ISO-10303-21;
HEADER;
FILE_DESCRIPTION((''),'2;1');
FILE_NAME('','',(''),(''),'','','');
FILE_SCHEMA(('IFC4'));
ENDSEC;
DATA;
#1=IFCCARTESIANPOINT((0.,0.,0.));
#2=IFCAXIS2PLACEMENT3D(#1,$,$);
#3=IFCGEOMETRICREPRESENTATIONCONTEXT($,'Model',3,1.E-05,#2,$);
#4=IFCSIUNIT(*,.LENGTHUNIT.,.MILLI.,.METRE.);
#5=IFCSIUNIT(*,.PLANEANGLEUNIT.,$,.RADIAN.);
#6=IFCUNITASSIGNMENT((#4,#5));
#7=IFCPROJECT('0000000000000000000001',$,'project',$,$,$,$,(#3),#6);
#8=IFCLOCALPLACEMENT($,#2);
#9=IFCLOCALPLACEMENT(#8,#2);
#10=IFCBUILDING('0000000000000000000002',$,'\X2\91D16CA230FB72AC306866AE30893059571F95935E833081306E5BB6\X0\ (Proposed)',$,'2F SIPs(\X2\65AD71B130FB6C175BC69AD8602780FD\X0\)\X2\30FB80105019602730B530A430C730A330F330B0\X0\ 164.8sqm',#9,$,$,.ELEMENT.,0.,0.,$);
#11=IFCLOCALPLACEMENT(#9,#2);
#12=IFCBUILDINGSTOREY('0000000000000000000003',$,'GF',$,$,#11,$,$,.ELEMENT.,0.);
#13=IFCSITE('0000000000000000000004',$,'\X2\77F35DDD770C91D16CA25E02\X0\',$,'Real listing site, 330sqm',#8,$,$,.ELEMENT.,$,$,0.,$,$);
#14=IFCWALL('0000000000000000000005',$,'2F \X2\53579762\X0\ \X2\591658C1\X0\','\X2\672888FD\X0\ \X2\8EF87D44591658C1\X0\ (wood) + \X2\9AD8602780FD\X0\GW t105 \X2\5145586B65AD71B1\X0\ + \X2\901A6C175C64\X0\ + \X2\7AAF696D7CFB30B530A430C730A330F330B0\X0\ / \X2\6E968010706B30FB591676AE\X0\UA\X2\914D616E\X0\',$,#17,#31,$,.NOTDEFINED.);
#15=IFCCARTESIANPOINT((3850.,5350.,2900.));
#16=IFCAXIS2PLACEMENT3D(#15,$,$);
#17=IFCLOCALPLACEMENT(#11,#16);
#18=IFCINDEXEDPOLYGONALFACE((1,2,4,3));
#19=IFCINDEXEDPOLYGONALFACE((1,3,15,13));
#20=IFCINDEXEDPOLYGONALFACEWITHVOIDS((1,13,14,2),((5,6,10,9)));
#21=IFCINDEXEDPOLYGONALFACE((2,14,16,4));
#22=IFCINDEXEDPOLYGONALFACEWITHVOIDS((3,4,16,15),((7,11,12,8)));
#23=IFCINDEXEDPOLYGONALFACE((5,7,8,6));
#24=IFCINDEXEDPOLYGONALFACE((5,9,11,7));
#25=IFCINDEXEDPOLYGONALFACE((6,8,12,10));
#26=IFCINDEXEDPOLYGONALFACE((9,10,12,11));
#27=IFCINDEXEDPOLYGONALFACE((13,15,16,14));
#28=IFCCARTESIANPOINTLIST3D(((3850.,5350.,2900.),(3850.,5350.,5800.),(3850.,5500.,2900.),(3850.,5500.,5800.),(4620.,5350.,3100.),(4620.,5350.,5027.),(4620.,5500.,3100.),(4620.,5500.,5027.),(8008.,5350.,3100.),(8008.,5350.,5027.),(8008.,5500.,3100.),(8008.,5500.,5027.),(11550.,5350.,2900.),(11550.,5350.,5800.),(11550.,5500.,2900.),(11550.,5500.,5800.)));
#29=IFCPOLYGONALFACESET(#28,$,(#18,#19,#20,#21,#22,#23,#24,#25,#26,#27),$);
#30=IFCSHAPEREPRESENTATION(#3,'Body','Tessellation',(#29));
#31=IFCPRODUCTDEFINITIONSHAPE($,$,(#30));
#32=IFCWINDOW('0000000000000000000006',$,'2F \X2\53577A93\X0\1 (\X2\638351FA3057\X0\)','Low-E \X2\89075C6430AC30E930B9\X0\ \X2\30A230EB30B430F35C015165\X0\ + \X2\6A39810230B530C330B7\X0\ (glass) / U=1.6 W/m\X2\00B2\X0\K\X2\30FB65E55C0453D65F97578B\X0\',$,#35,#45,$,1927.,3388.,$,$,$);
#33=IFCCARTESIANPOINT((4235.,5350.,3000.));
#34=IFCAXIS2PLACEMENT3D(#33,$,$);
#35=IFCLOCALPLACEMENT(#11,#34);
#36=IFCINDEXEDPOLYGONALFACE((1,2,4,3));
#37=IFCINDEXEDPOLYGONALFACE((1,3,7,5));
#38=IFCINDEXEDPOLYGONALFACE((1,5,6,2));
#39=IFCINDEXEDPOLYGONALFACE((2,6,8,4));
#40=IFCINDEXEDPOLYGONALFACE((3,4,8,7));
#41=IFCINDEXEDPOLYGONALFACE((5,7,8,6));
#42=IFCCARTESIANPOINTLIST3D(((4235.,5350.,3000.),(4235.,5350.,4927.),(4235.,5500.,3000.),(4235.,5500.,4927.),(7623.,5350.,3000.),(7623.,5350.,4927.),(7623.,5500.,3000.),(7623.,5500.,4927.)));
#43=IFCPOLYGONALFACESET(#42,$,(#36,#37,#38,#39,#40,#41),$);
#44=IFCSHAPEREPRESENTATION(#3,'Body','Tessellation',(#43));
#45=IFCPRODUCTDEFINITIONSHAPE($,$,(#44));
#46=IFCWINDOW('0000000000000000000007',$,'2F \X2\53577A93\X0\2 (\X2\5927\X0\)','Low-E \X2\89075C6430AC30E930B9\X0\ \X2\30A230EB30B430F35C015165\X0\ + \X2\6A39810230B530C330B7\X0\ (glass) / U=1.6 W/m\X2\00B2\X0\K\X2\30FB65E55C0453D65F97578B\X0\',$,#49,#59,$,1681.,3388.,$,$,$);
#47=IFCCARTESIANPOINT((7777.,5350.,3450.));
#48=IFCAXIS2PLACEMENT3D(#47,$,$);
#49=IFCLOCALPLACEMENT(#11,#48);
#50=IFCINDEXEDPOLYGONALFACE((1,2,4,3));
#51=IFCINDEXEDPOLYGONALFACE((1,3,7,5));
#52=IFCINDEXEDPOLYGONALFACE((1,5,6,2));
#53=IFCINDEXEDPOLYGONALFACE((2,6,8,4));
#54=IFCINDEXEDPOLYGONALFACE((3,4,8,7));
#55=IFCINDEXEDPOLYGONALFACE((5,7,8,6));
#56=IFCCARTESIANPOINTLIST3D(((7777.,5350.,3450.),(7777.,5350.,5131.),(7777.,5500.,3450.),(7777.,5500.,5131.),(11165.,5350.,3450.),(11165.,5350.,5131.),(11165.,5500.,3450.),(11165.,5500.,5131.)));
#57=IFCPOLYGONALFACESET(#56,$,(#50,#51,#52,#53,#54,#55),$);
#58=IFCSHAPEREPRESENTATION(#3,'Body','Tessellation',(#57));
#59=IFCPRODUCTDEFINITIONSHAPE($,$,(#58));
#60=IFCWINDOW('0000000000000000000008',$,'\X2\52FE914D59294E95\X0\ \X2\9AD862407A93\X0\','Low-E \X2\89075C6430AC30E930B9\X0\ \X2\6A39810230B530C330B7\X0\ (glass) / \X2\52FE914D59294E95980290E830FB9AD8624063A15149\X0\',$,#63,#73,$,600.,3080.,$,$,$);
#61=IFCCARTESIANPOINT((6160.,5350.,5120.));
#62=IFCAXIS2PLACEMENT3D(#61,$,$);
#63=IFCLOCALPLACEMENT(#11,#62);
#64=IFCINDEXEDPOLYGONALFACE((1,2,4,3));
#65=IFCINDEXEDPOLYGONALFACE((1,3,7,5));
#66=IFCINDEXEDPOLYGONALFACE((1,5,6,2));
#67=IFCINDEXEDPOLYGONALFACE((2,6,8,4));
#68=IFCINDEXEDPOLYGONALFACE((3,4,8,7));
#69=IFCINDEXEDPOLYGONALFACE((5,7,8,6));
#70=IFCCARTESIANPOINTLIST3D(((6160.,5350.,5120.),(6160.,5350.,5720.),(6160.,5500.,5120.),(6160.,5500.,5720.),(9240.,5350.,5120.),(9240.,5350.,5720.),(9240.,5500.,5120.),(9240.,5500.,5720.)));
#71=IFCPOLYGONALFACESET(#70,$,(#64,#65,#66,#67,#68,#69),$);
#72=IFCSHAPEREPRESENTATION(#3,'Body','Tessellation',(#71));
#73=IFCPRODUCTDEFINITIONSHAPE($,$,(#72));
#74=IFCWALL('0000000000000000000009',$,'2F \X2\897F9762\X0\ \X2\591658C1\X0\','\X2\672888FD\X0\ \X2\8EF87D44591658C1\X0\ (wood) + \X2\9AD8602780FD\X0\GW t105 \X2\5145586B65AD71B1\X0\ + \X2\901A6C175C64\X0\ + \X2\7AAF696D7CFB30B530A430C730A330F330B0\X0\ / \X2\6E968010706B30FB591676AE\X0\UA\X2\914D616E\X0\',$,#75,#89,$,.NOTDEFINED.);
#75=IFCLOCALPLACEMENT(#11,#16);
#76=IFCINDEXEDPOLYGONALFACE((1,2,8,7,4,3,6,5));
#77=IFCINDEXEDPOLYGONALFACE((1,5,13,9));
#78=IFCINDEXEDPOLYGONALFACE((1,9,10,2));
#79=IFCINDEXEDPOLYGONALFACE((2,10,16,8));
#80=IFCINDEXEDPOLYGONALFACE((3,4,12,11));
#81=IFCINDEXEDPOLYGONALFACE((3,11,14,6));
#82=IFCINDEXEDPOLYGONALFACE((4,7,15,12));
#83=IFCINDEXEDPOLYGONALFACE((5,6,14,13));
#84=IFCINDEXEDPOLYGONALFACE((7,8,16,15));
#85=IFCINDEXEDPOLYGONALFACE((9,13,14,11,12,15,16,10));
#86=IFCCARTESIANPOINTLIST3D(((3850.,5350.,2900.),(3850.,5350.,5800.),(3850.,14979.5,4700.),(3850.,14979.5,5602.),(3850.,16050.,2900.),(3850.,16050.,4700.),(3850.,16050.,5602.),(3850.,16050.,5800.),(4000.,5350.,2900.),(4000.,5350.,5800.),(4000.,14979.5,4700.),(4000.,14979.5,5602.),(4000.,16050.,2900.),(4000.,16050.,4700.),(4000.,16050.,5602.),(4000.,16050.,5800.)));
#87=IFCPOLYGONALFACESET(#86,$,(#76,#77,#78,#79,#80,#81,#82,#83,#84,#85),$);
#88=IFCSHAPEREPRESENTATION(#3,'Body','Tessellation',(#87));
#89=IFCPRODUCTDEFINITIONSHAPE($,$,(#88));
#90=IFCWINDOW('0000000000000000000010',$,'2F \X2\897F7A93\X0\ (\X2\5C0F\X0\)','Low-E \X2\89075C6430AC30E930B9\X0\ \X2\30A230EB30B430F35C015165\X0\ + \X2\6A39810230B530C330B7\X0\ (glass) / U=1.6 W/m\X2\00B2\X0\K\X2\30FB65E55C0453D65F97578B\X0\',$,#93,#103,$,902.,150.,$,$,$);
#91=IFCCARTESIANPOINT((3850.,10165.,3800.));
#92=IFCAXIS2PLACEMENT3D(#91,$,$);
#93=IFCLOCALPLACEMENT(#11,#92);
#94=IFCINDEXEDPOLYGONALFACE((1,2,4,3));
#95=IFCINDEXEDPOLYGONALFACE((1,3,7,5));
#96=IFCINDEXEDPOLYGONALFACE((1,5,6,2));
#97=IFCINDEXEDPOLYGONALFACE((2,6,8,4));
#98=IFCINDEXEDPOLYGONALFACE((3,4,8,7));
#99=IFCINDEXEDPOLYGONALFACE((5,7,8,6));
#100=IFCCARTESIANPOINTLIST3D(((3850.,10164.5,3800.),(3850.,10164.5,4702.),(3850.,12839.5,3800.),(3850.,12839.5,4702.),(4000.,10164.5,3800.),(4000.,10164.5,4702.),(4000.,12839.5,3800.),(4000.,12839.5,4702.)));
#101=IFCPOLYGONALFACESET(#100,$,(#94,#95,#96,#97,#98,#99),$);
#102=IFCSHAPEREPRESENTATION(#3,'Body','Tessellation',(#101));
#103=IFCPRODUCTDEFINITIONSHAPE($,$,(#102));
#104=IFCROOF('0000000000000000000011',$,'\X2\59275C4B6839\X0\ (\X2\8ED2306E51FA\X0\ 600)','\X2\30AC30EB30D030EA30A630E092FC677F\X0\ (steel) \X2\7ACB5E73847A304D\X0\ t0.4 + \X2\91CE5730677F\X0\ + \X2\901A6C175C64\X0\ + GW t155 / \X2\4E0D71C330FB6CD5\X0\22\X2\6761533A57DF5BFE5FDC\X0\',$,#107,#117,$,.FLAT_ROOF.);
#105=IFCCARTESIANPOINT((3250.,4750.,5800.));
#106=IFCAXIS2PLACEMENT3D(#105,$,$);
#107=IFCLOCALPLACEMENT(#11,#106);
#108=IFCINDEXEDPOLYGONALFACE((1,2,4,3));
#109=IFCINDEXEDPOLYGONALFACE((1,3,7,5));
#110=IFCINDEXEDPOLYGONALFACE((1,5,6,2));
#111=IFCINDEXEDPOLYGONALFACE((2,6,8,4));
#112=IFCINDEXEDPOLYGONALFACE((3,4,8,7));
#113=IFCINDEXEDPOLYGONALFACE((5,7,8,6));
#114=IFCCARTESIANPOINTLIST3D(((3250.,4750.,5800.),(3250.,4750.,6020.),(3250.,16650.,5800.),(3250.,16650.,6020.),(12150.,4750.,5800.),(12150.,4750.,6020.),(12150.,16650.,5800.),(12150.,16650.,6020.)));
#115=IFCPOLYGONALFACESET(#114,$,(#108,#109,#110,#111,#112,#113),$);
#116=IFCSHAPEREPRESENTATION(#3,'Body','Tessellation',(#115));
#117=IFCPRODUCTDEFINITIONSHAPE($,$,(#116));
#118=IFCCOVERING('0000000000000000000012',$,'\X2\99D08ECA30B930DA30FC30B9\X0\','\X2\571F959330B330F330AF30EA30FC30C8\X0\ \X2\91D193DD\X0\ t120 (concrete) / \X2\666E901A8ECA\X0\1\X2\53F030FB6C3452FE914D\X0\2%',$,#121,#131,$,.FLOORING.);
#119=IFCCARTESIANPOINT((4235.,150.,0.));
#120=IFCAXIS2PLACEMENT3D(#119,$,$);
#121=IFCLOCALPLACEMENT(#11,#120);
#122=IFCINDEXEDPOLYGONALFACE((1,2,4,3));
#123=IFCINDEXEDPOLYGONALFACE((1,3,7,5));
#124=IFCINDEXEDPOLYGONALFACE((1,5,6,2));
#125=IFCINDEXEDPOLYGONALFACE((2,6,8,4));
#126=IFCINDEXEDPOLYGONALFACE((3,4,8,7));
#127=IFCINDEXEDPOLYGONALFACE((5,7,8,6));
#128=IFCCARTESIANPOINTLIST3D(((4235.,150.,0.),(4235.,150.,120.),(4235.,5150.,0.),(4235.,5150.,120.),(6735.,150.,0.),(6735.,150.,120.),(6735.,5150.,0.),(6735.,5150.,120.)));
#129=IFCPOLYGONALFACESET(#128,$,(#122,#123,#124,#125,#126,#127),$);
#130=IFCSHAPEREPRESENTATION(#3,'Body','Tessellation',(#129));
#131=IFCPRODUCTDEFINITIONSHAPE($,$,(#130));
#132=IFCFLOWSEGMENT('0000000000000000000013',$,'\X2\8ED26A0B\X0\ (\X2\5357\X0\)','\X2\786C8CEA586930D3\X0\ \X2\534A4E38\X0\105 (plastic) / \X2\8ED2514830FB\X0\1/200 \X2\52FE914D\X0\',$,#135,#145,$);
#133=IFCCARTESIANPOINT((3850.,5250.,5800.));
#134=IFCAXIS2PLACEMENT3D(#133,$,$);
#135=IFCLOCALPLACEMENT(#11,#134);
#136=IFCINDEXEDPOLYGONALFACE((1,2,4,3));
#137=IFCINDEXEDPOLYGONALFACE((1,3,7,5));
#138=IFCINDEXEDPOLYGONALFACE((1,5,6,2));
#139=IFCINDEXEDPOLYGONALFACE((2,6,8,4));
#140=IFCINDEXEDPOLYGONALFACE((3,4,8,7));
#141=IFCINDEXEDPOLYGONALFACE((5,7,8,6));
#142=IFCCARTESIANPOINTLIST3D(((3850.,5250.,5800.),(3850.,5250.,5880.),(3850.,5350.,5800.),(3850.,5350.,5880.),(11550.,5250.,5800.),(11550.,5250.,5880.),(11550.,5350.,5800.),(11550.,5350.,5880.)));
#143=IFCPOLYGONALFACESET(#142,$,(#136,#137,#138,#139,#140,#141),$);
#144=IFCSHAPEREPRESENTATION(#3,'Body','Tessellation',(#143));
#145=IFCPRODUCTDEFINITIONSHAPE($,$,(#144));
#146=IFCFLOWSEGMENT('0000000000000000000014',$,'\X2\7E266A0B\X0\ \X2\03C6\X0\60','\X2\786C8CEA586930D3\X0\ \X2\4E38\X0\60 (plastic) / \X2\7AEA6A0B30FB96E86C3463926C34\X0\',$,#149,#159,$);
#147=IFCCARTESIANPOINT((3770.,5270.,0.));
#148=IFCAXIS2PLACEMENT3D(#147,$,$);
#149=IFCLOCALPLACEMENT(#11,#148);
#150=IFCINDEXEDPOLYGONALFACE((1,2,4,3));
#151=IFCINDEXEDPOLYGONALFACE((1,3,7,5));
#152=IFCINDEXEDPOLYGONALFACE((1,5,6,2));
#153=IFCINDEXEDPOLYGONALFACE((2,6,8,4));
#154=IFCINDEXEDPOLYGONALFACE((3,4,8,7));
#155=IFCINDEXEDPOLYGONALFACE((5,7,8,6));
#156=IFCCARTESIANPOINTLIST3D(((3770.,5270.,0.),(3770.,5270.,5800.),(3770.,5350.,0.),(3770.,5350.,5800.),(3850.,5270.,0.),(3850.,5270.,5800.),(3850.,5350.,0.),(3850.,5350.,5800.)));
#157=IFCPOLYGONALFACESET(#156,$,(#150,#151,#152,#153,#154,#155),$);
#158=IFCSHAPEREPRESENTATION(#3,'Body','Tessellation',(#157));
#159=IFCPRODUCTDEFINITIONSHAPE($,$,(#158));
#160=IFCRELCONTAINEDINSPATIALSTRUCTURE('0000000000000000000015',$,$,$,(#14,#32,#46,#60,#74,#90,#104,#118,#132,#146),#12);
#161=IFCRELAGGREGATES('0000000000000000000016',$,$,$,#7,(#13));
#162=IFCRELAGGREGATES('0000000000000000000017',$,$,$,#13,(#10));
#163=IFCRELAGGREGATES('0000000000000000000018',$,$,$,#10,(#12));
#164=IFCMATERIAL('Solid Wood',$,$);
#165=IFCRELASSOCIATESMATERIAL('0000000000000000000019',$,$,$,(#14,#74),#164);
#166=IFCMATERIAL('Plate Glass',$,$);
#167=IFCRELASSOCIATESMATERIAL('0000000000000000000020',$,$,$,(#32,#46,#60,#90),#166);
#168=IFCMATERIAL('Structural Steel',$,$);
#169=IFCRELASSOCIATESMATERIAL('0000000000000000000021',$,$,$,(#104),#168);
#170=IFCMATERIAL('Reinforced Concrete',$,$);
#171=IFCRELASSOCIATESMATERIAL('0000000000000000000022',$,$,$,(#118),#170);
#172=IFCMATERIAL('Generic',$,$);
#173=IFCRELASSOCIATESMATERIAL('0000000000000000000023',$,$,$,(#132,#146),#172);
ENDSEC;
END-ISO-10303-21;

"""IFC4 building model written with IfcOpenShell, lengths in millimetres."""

from ifc_helpers import new_model, si_unit, frame, frame_2d, origin, place, context, project, spatial, rectangle, extrude, material, element, fill, save


model = new_model("IFC4")

# Units and contexts
model_context = context("Model", 3, precision=1e-05, world=origin())
ifc_project = project(units=[si_unit("LENGTHUNIT", "METRE", prefix="MILLI"), si_unit("PLANEANGLEUNIT", "RADIAN")], contexts=[model_context])

# Site, building, storey
site_placement = place(None, origin())
site = spatial("IfcSite", under=ifc_project, at=site_placement, Name="石川県金沢市", ObjectType="Real listing site, 330sqm", CompositionType="ELEMENT", RefElevation=0.0)
building_placement = place(site_placement, origin())
building = spatial("IfcBuilding", under=site, at=building_placement, Name="金沢・犬と暮らす土間広めの家 (Proposed)", ObjectType="2F SIPs(断熱・気密高性能)・耐候性サイディング 164.8sqm", CompositionType="ELEMENT", ElevationOfRefHeight=0.0, ElevationOfTerrain=0.0)
storey_placement = place(building_placement, origin())
storey = spatial("IfcBuildingStorey", under=building, at=storey_placement, Name="GF", CompositionType="ELEMENT", Elevation=0.0)

# Shared definitions
ifc_material_1 = material(Name="Solid Wood")

# Shared definitions
ifc_material_2 = material(Name="Reinforced Concrete")

# Shared definitions
ifc_material_3 = material(Name="Plate Glass")

# Wall, openings, windows
wall_1_placement = place(storey_placement, frame((3850.0, 5350.0, 2900.0)))
wall_1 = element("IfcWall", 1, at=wall_1_placement, inside=storey, material=ifc_material_1, Name="2F 南面 外壁", Description="木製 軸組外壁 (wood) + 高性能GW t105 充填断熱 + 通気層 + 窯業系サイディング / 準耐火・外皮UA配慮", PredefinedType="NOTDEFINED", context=model_context, shape_type="SweptSolid", body=[
    extrude(rectangle(XDim=7700.0, YDim=150.0, at=frame_2d((3850.0, 75.0))), frame((3850.0, 5350.0, 2900.0)), (0.0, 0.0, 1.0), 2900.0),
])
opening_1_placement = place(storey_placement, frame((4235.0, 5350.0, 3000.0)))
opening_1 = element("IfcOpeningElement", 2, at=opening_1_placement, cuts=wall_1, PredefinedType="NOTDEFINED", context=model_context, shape_type="SweptSolid", body=[
    extrude(rectangle(XDim=3388.0, YDim=150.0, at=frame_2d((1694.0, 75.0))), frame((4235.0, 5350.0, 3000.0)), (0.0, 0.0, 1.0), 1927.0),
])
opening_2_placement = place(storey_placement, frame((7777.0, 5350.0, 3450.0)))
opening_2 = element("IfcOpeningElement", 3, at=opening_2_placement, cuts=wall_1, PredefinedType="NOTDEFINED", context=model_context, shape_type="SweptSolid", body=[
    extrude(rectangle(XDim=3388.0, YDim=150.0, at=frame_2d((1694.0, 75.0))), frame((7777.0, 5350.0, 3450.0)), (0.0, 0.0, 1.0), 1681.0),
])
opening_3_placement = place(storey_placement, frame((6160.0, 5350.0, 5120.0)))
opening_3 = element("IfcOpeningElement", 4, at=opening_3_placement, cuts=wall_1, PredefinedType="NOTDEFINED", context=model_context, shape_type="SweptSolid", body=[
    extrude(rectangle(XDim=3080.0, YDim=150.0, at=frame_2d((1540.0, 75.0))), frame((6160.0, 5350.0, 5120.0)), (0.0, 0.0, 1.0), 600.0),
])
window_1_placement = place(storey_placement, frame((4235.0, 5350.0, 3000.0)))
window_1 = element("IfcWindow", 5, at=window_1_placement, inside=storey, material=ifc_material_3, Name="2F 南窓1 (掃出し)", Description="Low-E 複層ガラス アルゴン封入 + 樹脂サッシ (glass) / U=1.6 W/m²K・日射取得型", OverallHeight=1927.0, OverallWidth=3388.0, context=model_context, shape_type="SweptSolid", body=[
    extrude(rectangle(XDim=3388.0, YDim=150.0, at=frame_2d((1694.0, 75.0))), frame((4235.0, 5350.0, 3000.0)), (0.0, 0.0, 1.0), 1927.0),
])
fill(opening_1, window_1)
window_2_placement = place(storey_placement, frame((7777.0, 5350.0, 3450.0)))
window_2 = element("IfcWindow", 6, at=window_2_placement, inside=storey, material=ifc_material_3, Name="2F 南窓2 (大)", Description="Low-E 複層ガラス アルゴン封入 + 樹脂サッシ (glass) / U=1.6 W/m²K・日射取得型", OverallHeight=1681.0, OverallWidth=3388.0, context=model_context, shape_type="SweptSolid", body=[
    extrude(rectangle(XDim=3388.0, YDim=150.0, at=frame_2d((1694.0, 75.0))), frame((7777.0, 5350.0, 3450.0)), (0.0, 0.0, 1.0), 1681.0),
])
fill(opening_2, window_2)
window_3_placement = place(storey_placement, frame((6160.0, 5350.0, 5120.0)))
window_3 = element("IfcWindow", 7, at=window_3_placement, inside=storey, material=ifc_material_3, Name="勾配天井 高所窓", Description="Low-E 複層ガラス 樹脂サッシ (glass) / 勾配天井頂部・高所採光", OverallHeight=600.0, OverallWidth=3080.0, context=model_context, shape_type="SweptSolid", body=[
    extrude(rectangle(XDim=3080.0, YDim=150.0, at=frame_2d((1540.0, 75.0))), frame((6160.0, 5350.0, 5120.0)), (0.0, 0.0, 1.0), 600.0),
])
fill(opening_3, window_3)

# Wall, opening, window
wall_2_placement = place(storey_placement, frame((3850.0, 5350.0, 2900.0)))
wall_2 = element("IfcWall", 8, at=wall_2_placement, inside=storey, material=ifc_material_1, Name="2F 西面 外壁", Description="木製 軸組外壁 (wood) + 高性能GW t105 充填断熱 + 通気層 + 窯業系サイディング / 準耐火・外皮UA配慮", PredefinedType="NOTDEFINED", context=model_context, shape_type="SweptSolid", body=[
    extrude(rectangle(XDim=150.0, YDim=10700.0, at=frame_2d((75.0, 5350.0))), frame((3850.0, 5350.0, 2900.0)), (0.0, 0.0, 1.0), 2900.0),
])
opening_4_placement = place(storey_placement, frame((3850.0, 10165.0, 3800.0)))
opening_4 = element("IfcOpeningElement", 9, at=opening_4_placement, cuts=wall_2, PredefinedType="NOTDEFINED", context=model_context, shape_type="SweptSolid", body=[
    extrude(rectangle(XDim=150.0, YDim=2675.0, at=frame_2d((75.0, 1337.0))), frame((3850.0, 10165.0, 3800.0)), (0.0, 0.0, 1.0), 902.0),
])
window_4_placement = place(storey_placement, frame((3850.0, 10165.0, 3800.0)))
window_4 = element("IfcWindow", 10, at=window_4_placement, inside=storey, material=ifc_material_3, Name="2F 西窓 (小)", Description="Low-E 複層ガラス アルゴン封入 + 樹脂サッシ (glass) / U=1.6 W/m²K・日射取得型", OverallHeight=902.0, OverallWidth=150.0, context=model_context, shape_type="SweptSolid", body=[
    extrude(rectangle(XDim=150.0, YDim=2675.0, at=frame_2d((75.0, 1337.0))), frame((3850.0, 10165.0, 3800.0)), (0.0, 0.0, 1.0), 902.0),
])
fill(opening_4, window_4)

# Roof
ifc_material_4 = material(Name="Structural Steel")
roof_placement = place(storey_placement, frame((3250.0, 4750.0, 5800.0)))
element("IfcRoof", 11, at=roof_placement, inside=storey, material=ifc_material_4, Name="大屋根 (軒の出 600)", Description="ガルバリウム鋼板 (steel) 立平葺き t0.4 + 野地板 + 通気層 + GW t155 / 不燃・法22条区域対応", PredefinedType="FLAT_ROOF", context=model_context, shape_type="SweptSolid", body=[
    extrude(rectangle(XDim=8900.0, YDim=11900.0, at=frame_2d((4450.0, 5950.0))), frame((3250.0, 4750.0, 5800.0)), (0.0, 0.0, 1.0), 220.0),
])

# Covering
covering_placement = place(storey_placement, frame((4235.0, 150.0, 0.0)))
element("IfcCovering", 12, at=covering_placement, inside=storey, material=ifc_material_2, Name="駐車スペース", Description="土間コンクリート 金鏝 t120 (concrete) / 普通車1台・水勾配2%", PredefinedType="FLOORING", context=model_context, shape_type="SweptSolid", body=[
    extrude(rectangle(XDim=2500.0, YDim=5000.0, at=frame_2d((1250.0, 2500.0))), frame((4235.0, 150.0, 0.0)), (0.0, 0.0, 1.0), 120.0),
])

# Flow segments
ifc_material_5 = material(Name="Generic")
flow_segment_1_placement = place(storey_placement, frame((3850.0, 5250.0, 5800.0)))
element("IfcFlowSegment", 13, at=flow_segment_1_placement, inside=storey, material=ifc_material_5, Name="軒樋 (南)", Description="硬質塩ビ 半丸105 (plastic) / 軒先・1/200 勾配", context=model_context, shape_type="SweptSolid", body=[
    extrude(rectangle(XDim=7700.0, YDim=100.0, at=frame_2d((3850.0, 50.0))), frame((3850.0, 5250.0, 5800.0)), (0.0, 0.0, 1.0), 80.0),
])
flow_segment_2_placement = place(storey_placement, frame((3770.0, 5270.0, 0.0)))
element("IfcFlowSegment", 14, at=flow_segment_2_placement, inside=storey, material=ifc_material_5, Name="縦樋 φ60", Description="硬質塩ビ 丸60 (plastic) / 竪樋・雨水排水", context=model_context, shape_type="SweptSolid", body=[
    extrude(rectangle(XDim=80.0, YDim=80.0, at=frame_2d((40.0, 40.0))), frame((3770.0, 5270.0, 0.0)), (0.0, 0.0, 1.0), 5800.0),
])

save(model, "model.ifc")
